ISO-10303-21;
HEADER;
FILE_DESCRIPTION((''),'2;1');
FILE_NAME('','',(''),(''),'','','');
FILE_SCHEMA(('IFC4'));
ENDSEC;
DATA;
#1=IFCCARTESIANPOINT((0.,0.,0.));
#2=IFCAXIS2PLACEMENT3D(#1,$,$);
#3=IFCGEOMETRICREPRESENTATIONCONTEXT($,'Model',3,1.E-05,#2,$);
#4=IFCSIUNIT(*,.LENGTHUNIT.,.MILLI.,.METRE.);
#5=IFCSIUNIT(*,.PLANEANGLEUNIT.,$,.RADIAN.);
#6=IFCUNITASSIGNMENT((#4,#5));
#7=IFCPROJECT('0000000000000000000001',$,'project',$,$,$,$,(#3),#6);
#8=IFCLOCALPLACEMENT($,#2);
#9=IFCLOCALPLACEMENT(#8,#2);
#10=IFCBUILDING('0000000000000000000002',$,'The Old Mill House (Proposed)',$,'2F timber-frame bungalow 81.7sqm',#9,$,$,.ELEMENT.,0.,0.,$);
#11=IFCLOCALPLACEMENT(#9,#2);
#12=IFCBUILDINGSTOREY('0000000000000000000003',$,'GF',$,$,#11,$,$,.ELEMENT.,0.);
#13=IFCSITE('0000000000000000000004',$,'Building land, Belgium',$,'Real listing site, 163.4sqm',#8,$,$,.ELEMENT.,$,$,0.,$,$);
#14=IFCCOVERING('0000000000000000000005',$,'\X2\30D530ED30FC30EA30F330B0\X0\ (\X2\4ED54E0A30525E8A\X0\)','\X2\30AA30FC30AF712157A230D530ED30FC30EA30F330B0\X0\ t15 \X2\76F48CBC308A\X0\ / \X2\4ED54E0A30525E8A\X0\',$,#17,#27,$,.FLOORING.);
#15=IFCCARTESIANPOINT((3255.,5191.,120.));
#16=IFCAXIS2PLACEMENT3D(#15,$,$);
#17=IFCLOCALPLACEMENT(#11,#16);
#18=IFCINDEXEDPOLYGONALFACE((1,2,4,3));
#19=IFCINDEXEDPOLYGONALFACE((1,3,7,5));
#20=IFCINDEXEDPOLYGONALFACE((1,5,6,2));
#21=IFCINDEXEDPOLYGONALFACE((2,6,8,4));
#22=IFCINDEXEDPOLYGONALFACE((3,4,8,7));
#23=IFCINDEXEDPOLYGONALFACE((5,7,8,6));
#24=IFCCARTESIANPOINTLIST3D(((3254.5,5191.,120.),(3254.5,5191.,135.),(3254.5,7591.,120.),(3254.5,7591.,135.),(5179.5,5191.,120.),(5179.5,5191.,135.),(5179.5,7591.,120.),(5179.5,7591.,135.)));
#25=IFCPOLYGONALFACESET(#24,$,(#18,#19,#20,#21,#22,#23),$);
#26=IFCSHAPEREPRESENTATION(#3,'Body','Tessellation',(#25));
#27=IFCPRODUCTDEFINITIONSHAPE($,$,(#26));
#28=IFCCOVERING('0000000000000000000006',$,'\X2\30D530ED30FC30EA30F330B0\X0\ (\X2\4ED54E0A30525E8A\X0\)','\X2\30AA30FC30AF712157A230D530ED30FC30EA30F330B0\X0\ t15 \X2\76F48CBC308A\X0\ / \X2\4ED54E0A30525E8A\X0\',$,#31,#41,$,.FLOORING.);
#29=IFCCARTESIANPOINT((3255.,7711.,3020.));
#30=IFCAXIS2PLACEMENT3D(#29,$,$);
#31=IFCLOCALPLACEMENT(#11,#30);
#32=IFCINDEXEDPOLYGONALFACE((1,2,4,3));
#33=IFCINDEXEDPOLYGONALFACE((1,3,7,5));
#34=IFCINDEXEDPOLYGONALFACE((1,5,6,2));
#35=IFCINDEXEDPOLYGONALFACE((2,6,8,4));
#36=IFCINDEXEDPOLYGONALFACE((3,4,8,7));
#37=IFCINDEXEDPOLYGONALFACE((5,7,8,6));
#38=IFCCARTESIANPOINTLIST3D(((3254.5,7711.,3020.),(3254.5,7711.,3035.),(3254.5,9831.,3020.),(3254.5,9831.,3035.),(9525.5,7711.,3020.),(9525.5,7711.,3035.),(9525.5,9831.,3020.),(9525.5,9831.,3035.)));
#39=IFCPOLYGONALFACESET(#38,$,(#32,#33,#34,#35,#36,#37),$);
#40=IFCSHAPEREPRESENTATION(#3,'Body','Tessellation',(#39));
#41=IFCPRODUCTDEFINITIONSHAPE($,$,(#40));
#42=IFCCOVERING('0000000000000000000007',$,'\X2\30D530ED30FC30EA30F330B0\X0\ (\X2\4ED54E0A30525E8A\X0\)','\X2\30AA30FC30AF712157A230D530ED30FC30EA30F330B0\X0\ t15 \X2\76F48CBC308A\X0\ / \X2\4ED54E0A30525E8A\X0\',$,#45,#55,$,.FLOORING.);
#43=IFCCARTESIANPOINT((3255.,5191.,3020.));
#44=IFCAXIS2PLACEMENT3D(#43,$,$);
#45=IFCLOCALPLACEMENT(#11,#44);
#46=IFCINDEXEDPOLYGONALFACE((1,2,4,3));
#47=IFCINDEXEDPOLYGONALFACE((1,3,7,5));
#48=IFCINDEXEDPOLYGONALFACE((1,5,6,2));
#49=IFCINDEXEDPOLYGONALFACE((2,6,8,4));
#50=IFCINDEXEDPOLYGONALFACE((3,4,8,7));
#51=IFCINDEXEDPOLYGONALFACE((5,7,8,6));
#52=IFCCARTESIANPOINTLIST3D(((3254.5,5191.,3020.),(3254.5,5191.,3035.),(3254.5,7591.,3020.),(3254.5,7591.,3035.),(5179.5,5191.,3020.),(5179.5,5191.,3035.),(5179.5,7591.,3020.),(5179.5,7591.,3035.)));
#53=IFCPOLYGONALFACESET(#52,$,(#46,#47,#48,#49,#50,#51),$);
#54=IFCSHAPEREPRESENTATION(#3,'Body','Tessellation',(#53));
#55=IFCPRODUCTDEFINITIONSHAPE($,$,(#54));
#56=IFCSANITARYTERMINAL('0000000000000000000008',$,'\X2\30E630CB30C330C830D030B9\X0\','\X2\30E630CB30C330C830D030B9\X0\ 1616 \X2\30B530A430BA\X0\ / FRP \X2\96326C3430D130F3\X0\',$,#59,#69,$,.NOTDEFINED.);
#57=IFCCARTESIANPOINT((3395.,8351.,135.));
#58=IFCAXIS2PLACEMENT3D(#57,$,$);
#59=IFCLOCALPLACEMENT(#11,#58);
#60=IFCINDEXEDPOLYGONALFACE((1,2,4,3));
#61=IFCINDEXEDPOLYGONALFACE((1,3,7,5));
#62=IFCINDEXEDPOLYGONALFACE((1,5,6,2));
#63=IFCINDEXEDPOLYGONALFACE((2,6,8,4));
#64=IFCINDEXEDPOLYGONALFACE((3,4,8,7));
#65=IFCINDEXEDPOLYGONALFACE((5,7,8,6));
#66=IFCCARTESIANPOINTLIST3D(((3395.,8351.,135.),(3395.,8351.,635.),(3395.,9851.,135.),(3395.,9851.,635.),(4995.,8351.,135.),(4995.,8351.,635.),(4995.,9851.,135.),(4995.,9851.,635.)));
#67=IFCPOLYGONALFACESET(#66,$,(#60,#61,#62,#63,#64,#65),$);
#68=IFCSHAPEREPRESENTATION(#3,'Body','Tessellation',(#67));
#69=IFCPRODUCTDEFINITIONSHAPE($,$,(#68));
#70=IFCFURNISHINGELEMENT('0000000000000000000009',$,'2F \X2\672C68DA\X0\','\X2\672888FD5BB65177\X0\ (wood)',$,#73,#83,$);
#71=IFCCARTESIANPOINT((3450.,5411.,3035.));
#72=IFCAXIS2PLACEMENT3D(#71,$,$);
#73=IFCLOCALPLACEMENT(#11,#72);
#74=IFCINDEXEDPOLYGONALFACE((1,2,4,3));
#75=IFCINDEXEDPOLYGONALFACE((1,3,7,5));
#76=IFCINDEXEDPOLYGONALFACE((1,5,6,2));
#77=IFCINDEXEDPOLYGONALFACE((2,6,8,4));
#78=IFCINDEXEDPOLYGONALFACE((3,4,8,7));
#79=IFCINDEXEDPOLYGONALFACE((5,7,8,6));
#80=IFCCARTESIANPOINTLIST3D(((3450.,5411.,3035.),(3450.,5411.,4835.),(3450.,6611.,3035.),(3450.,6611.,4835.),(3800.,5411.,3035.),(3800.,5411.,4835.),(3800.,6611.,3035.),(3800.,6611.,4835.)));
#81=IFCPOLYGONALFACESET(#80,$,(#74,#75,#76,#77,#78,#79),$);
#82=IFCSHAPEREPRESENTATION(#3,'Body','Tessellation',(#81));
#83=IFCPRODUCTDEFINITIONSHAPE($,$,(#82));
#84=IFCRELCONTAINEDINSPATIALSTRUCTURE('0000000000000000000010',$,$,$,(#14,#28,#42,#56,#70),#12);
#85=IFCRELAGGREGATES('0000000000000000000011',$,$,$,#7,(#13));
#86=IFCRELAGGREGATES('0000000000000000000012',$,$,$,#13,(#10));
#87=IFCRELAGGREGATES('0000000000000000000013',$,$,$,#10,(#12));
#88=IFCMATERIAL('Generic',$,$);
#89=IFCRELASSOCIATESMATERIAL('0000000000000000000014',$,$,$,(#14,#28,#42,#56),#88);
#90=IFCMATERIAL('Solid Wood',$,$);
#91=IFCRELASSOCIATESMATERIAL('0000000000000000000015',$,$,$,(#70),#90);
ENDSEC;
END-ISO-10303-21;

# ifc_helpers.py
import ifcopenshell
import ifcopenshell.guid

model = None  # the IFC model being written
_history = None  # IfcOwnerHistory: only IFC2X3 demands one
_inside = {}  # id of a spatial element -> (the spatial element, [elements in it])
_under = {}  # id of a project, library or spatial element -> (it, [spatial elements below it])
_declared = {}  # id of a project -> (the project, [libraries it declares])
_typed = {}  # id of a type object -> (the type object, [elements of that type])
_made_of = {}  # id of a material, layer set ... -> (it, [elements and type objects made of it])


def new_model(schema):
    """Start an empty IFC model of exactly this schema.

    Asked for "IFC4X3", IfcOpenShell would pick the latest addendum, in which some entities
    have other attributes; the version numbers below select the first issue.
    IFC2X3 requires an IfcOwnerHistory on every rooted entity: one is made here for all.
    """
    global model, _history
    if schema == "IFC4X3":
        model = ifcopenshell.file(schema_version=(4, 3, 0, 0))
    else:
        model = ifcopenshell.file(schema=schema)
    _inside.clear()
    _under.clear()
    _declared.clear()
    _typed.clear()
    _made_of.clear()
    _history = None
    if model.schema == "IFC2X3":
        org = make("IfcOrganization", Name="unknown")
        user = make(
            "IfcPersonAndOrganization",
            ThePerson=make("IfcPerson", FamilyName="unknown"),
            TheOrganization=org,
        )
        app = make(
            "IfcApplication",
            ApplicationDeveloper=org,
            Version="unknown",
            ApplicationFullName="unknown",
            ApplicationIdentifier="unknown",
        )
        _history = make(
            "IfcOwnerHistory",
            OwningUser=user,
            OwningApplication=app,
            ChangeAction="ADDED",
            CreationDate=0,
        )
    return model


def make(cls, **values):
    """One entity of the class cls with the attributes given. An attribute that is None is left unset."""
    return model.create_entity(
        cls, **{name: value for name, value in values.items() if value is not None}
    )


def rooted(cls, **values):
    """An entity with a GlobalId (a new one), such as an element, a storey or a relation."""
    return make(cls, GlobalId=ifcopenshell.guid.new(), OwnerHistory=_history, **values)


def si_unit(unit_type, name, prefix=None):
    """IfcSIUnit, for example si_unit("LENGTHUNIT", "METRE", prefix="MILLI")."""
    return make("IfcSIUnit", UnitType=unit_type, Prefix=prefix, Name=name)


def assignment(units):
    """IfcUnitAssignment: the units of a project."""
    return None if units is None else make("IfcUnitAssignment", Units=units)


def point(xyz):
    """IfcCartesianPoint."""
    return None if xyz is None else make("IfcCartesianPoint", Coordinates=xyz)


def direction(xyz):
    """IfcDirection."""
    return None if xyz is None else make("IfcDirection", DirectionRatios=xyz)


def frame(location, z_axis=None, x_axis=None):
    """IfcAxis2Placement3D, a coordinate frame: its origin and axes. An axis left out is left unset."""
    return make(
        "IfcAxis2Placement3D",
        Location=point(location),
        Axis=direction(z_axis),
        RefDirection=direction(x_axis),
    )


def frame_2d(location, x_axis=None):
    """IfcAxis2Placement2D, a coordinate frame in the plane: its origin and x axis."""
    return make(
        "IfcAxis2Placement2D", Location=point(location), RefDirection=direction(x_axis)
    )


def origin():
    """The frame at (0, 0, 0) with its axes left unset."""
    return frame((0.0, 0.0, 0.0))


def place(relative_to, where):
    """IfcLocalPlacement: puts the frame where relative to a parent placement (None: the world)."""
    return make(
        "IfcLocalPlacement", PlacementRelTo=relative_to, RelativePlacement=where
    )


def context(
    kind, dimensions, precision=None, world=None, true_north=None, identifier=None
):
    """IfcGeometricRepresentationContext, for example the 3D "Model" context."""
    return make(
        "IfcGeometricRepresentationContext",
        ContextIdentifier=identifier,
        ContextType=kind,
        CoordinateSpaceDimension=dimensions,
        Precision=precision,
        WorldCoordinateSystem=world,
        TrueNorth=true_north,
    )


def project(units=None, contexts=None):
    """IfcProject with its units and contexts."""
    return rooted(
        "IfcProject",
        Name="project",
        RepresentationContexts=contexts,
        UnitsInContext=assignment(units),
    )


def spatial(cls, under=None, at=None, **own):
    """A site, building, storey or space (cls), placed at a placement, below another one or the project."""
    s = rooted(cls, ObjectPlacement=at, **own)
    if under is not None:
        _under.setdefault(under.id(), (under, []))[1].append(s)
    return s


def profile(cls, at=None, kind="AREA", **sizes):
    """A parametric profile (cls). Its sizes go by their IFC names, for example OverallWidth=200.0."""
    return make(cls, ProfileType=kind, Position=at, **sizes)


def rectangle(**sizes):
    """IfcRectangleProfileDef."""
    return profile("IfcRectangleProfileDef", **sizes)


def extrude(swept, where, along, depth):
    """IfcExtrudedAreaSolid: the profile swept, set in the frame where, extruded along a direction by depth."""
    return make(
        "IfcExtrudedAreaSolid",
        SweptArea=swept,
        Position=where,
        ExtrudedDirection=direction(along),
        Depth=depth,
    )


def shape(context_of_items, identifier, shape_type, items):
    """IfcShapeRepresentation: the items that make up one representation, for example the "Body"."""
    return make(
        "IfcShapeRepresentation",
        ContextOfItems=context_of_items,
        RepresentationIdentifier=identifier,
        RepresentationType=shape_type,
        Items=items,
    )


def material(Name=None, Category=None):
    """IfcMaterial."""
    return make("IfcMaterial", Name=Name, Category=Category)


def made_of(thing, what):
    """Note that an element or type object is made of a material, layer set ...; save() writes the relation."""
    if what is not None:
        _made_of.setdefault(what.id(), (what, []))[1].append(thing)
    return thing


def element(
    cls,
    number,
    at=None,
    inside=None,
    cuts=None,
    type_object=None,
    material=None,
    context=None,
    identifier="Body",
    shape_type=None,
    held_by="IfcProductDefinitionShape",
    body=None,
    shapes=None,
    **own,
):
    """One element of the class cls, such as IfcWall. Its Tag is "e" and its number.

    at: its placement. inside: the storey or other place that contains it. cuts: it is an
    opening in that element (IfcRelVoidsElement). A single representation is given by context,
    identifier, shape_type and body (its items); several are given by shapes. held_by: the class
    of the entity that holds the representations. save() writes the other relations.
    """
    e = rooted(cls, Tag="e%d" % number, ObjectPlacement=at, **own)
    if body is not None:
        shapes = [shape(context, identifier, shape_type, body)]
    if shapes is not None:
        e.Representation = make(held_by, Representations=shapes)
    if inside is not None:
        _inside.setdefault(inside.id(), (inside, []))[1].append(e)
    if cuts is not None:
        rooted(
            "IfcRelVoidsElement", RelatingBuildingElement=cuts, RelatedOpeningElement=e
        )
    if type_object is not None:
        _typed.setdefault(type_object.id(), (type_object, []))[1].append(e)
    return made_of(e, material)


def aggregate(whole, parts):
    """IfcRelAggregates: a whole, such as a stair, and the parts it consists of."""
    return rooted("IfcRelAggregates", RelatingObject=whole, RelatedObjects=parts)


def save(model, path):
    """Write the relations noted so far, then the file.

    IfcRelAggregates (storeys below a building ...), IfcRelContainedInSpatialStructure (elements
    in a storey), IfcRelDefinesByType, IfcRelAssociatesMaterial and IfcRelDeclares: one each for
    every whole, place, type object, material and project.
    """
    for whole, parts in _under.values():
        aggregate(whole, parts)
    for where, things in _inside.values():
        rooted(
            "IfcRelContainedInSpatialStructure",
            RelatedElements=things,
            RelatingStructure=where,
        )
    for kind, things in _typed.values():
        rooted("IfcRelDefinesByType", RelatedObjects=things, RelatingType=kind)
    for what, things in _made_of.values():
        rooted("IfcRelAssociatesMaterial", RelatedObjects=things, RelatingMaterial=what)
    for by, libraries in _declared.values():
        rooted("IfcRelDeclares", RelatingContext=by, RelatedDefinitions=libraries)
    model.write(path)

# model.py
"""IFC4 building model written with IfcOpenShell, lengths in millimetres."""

from ifc_helpers import new_model, si_unit, frame, frame_2d, origin, place, context, project, spatial, rectangle, extrude, material, element, save


model = new_model("IFC4")

# Units and contexts
model_context = context("Model", 3, precision=1e-05, world=origin())
ifc_project = project(units=[si_unit("LENGTHUNIT", "METRE", prefix="MILLI"), si_unit("PLANEANGLEUNIT", "RADIAN")], contexts=[model_context])

# Site, building, storey
site_placement = place(None, origin())
site = spatial("IfcSite", under=ifc_project, at=site_placement, Name="Building land, Belgium", ObjectType="Real listing site, 163.4sqm", CompositionType="ELEMENT", RefElevation=0.0)
building_placement = place(site_placement, origin())
building = spatial("IfcBuilding", under=site, at=building_placement, Name="The Old Mill House (Proposed)", ObjectType="2F timber-frame bungalow 81.7sqm", CompositionType="ELEMENT", ElevationOfRefHeight=0.0, ElevationOfTerrain=0.0)
storey_placement = place(building_placement, origin())
storey = spatial("IfcBuildingStorey", under=building, at=storey_placement, Name="GF", CompositionType="ELEMENT", Elevation=0.0)

# Shared definitions
ifc_material_1 = material(Name="Solid Wood")

# Coverings
ifc_material_2 = material(Name="Generic")
covering_1_placement = place(storey_placement, frame((3255.0, 5191.0, 120.0)))
element("IfcCovering", 1, at=covering_1_placement, inside=storey, material=ifc_material_2, Name="フローリング (仕上げ床)", Description="オーク無垢フローリング t15 直貼り / 仕上げ床", PredefinedType="FLOORING", context=model_context, shape_type="SweptSolid", body=[
    extrude(rectangle(XDim=1925.0, YDim=2400.0, at=frame_2d((962.0, 1200.0))), frame((3255.0, 5191.0, 120.0)), (0.0, 0.0, 1.0), 15.0),
])
covering_2_placement = place(storey_placement, frame((3255.0, 7711.0, 3020.0)))
element("IfcCovering", 2, at=covering_2_placement, inside=storey, material=ifc_material_2, Name="フローリング (仕上げ床)", Description="オーク無垢フローリング t15 直貼り / 仕上げ床", PredefinedType="FLOORING", context=model_context, shape_type="SweptSolid", body=[
    extrude(rectangle(XDim=6271.0, YDim=2120.0, at=frame_2d((3135.0, 1060.0))), frame((3255.0, 7711.0, 3020.0)), (0.0, 0.0, 1.0), 15.0),
])
covering_3_placement = place(storey_placement, frame((3255.0, 5191.0, 3020.0)))
element("IfcCovering", 3, at=covering_3_placement, inside=storey, material=ifc_material_2, Name="フローリング (仕上げ床)", Description="オーク無垢フローリング t15 直貼り / 仕上げ床", PredefinedType="FLOORING", context=model_context, shape_type="SweptSolid", body=[
    extrude(rectangle(XDim=1925.0, YDim=2400.0, at=frame_2d((962.0, 1200.0))), frame((3255.0, 5191.0, 3020.0)), (0.0, 0.0, 1.0), 15.0),
])

# Sanitary terminal
sanitary_terminal_placement = place(storey_placement, frame((3395.0, 8351.0, 135.0)))
element("IfcSanitaryTerminal", 4, at=sanitary_terminal_placement, inside=storey, material=ifc_material_2, Name="ユニットバス", Description="ユニットバス 1616 サイズ / FRP 防水パン", PredefinedType="NOTDEFINED", context=model_context, shape_type="SweptSolid", body=[
    extrude(rectangle(XDim=1600.0, YDim=1500.0, at=frame_2d((800.0, 750.0))), frame((3395.0, 8351.0, 135.0)), (0.0, 0.0, 1.0), 500.0),
])

# Furnishing element
furnishing_placement = place(storey_placement, frame((3450.0, 5411.0, 3035.0)))
element("IfcFurnishingElement", 5, at=furnishing_placement, inside=storey, material=ifc_material_1, Name="2F 本棚", Description="木製家具 (wood)", context=model_context, shape_type="SweptSolid", body=[
    extrude(rectangle(XDim=350.0, YDim=1200.0, at=frame_2d((175.0, 600.0))), frame((3450.0, 5411.0, 3035.0)), (0.0, 0.0, 1.0), 1800.0),
])

save(model, "model.ifc")
